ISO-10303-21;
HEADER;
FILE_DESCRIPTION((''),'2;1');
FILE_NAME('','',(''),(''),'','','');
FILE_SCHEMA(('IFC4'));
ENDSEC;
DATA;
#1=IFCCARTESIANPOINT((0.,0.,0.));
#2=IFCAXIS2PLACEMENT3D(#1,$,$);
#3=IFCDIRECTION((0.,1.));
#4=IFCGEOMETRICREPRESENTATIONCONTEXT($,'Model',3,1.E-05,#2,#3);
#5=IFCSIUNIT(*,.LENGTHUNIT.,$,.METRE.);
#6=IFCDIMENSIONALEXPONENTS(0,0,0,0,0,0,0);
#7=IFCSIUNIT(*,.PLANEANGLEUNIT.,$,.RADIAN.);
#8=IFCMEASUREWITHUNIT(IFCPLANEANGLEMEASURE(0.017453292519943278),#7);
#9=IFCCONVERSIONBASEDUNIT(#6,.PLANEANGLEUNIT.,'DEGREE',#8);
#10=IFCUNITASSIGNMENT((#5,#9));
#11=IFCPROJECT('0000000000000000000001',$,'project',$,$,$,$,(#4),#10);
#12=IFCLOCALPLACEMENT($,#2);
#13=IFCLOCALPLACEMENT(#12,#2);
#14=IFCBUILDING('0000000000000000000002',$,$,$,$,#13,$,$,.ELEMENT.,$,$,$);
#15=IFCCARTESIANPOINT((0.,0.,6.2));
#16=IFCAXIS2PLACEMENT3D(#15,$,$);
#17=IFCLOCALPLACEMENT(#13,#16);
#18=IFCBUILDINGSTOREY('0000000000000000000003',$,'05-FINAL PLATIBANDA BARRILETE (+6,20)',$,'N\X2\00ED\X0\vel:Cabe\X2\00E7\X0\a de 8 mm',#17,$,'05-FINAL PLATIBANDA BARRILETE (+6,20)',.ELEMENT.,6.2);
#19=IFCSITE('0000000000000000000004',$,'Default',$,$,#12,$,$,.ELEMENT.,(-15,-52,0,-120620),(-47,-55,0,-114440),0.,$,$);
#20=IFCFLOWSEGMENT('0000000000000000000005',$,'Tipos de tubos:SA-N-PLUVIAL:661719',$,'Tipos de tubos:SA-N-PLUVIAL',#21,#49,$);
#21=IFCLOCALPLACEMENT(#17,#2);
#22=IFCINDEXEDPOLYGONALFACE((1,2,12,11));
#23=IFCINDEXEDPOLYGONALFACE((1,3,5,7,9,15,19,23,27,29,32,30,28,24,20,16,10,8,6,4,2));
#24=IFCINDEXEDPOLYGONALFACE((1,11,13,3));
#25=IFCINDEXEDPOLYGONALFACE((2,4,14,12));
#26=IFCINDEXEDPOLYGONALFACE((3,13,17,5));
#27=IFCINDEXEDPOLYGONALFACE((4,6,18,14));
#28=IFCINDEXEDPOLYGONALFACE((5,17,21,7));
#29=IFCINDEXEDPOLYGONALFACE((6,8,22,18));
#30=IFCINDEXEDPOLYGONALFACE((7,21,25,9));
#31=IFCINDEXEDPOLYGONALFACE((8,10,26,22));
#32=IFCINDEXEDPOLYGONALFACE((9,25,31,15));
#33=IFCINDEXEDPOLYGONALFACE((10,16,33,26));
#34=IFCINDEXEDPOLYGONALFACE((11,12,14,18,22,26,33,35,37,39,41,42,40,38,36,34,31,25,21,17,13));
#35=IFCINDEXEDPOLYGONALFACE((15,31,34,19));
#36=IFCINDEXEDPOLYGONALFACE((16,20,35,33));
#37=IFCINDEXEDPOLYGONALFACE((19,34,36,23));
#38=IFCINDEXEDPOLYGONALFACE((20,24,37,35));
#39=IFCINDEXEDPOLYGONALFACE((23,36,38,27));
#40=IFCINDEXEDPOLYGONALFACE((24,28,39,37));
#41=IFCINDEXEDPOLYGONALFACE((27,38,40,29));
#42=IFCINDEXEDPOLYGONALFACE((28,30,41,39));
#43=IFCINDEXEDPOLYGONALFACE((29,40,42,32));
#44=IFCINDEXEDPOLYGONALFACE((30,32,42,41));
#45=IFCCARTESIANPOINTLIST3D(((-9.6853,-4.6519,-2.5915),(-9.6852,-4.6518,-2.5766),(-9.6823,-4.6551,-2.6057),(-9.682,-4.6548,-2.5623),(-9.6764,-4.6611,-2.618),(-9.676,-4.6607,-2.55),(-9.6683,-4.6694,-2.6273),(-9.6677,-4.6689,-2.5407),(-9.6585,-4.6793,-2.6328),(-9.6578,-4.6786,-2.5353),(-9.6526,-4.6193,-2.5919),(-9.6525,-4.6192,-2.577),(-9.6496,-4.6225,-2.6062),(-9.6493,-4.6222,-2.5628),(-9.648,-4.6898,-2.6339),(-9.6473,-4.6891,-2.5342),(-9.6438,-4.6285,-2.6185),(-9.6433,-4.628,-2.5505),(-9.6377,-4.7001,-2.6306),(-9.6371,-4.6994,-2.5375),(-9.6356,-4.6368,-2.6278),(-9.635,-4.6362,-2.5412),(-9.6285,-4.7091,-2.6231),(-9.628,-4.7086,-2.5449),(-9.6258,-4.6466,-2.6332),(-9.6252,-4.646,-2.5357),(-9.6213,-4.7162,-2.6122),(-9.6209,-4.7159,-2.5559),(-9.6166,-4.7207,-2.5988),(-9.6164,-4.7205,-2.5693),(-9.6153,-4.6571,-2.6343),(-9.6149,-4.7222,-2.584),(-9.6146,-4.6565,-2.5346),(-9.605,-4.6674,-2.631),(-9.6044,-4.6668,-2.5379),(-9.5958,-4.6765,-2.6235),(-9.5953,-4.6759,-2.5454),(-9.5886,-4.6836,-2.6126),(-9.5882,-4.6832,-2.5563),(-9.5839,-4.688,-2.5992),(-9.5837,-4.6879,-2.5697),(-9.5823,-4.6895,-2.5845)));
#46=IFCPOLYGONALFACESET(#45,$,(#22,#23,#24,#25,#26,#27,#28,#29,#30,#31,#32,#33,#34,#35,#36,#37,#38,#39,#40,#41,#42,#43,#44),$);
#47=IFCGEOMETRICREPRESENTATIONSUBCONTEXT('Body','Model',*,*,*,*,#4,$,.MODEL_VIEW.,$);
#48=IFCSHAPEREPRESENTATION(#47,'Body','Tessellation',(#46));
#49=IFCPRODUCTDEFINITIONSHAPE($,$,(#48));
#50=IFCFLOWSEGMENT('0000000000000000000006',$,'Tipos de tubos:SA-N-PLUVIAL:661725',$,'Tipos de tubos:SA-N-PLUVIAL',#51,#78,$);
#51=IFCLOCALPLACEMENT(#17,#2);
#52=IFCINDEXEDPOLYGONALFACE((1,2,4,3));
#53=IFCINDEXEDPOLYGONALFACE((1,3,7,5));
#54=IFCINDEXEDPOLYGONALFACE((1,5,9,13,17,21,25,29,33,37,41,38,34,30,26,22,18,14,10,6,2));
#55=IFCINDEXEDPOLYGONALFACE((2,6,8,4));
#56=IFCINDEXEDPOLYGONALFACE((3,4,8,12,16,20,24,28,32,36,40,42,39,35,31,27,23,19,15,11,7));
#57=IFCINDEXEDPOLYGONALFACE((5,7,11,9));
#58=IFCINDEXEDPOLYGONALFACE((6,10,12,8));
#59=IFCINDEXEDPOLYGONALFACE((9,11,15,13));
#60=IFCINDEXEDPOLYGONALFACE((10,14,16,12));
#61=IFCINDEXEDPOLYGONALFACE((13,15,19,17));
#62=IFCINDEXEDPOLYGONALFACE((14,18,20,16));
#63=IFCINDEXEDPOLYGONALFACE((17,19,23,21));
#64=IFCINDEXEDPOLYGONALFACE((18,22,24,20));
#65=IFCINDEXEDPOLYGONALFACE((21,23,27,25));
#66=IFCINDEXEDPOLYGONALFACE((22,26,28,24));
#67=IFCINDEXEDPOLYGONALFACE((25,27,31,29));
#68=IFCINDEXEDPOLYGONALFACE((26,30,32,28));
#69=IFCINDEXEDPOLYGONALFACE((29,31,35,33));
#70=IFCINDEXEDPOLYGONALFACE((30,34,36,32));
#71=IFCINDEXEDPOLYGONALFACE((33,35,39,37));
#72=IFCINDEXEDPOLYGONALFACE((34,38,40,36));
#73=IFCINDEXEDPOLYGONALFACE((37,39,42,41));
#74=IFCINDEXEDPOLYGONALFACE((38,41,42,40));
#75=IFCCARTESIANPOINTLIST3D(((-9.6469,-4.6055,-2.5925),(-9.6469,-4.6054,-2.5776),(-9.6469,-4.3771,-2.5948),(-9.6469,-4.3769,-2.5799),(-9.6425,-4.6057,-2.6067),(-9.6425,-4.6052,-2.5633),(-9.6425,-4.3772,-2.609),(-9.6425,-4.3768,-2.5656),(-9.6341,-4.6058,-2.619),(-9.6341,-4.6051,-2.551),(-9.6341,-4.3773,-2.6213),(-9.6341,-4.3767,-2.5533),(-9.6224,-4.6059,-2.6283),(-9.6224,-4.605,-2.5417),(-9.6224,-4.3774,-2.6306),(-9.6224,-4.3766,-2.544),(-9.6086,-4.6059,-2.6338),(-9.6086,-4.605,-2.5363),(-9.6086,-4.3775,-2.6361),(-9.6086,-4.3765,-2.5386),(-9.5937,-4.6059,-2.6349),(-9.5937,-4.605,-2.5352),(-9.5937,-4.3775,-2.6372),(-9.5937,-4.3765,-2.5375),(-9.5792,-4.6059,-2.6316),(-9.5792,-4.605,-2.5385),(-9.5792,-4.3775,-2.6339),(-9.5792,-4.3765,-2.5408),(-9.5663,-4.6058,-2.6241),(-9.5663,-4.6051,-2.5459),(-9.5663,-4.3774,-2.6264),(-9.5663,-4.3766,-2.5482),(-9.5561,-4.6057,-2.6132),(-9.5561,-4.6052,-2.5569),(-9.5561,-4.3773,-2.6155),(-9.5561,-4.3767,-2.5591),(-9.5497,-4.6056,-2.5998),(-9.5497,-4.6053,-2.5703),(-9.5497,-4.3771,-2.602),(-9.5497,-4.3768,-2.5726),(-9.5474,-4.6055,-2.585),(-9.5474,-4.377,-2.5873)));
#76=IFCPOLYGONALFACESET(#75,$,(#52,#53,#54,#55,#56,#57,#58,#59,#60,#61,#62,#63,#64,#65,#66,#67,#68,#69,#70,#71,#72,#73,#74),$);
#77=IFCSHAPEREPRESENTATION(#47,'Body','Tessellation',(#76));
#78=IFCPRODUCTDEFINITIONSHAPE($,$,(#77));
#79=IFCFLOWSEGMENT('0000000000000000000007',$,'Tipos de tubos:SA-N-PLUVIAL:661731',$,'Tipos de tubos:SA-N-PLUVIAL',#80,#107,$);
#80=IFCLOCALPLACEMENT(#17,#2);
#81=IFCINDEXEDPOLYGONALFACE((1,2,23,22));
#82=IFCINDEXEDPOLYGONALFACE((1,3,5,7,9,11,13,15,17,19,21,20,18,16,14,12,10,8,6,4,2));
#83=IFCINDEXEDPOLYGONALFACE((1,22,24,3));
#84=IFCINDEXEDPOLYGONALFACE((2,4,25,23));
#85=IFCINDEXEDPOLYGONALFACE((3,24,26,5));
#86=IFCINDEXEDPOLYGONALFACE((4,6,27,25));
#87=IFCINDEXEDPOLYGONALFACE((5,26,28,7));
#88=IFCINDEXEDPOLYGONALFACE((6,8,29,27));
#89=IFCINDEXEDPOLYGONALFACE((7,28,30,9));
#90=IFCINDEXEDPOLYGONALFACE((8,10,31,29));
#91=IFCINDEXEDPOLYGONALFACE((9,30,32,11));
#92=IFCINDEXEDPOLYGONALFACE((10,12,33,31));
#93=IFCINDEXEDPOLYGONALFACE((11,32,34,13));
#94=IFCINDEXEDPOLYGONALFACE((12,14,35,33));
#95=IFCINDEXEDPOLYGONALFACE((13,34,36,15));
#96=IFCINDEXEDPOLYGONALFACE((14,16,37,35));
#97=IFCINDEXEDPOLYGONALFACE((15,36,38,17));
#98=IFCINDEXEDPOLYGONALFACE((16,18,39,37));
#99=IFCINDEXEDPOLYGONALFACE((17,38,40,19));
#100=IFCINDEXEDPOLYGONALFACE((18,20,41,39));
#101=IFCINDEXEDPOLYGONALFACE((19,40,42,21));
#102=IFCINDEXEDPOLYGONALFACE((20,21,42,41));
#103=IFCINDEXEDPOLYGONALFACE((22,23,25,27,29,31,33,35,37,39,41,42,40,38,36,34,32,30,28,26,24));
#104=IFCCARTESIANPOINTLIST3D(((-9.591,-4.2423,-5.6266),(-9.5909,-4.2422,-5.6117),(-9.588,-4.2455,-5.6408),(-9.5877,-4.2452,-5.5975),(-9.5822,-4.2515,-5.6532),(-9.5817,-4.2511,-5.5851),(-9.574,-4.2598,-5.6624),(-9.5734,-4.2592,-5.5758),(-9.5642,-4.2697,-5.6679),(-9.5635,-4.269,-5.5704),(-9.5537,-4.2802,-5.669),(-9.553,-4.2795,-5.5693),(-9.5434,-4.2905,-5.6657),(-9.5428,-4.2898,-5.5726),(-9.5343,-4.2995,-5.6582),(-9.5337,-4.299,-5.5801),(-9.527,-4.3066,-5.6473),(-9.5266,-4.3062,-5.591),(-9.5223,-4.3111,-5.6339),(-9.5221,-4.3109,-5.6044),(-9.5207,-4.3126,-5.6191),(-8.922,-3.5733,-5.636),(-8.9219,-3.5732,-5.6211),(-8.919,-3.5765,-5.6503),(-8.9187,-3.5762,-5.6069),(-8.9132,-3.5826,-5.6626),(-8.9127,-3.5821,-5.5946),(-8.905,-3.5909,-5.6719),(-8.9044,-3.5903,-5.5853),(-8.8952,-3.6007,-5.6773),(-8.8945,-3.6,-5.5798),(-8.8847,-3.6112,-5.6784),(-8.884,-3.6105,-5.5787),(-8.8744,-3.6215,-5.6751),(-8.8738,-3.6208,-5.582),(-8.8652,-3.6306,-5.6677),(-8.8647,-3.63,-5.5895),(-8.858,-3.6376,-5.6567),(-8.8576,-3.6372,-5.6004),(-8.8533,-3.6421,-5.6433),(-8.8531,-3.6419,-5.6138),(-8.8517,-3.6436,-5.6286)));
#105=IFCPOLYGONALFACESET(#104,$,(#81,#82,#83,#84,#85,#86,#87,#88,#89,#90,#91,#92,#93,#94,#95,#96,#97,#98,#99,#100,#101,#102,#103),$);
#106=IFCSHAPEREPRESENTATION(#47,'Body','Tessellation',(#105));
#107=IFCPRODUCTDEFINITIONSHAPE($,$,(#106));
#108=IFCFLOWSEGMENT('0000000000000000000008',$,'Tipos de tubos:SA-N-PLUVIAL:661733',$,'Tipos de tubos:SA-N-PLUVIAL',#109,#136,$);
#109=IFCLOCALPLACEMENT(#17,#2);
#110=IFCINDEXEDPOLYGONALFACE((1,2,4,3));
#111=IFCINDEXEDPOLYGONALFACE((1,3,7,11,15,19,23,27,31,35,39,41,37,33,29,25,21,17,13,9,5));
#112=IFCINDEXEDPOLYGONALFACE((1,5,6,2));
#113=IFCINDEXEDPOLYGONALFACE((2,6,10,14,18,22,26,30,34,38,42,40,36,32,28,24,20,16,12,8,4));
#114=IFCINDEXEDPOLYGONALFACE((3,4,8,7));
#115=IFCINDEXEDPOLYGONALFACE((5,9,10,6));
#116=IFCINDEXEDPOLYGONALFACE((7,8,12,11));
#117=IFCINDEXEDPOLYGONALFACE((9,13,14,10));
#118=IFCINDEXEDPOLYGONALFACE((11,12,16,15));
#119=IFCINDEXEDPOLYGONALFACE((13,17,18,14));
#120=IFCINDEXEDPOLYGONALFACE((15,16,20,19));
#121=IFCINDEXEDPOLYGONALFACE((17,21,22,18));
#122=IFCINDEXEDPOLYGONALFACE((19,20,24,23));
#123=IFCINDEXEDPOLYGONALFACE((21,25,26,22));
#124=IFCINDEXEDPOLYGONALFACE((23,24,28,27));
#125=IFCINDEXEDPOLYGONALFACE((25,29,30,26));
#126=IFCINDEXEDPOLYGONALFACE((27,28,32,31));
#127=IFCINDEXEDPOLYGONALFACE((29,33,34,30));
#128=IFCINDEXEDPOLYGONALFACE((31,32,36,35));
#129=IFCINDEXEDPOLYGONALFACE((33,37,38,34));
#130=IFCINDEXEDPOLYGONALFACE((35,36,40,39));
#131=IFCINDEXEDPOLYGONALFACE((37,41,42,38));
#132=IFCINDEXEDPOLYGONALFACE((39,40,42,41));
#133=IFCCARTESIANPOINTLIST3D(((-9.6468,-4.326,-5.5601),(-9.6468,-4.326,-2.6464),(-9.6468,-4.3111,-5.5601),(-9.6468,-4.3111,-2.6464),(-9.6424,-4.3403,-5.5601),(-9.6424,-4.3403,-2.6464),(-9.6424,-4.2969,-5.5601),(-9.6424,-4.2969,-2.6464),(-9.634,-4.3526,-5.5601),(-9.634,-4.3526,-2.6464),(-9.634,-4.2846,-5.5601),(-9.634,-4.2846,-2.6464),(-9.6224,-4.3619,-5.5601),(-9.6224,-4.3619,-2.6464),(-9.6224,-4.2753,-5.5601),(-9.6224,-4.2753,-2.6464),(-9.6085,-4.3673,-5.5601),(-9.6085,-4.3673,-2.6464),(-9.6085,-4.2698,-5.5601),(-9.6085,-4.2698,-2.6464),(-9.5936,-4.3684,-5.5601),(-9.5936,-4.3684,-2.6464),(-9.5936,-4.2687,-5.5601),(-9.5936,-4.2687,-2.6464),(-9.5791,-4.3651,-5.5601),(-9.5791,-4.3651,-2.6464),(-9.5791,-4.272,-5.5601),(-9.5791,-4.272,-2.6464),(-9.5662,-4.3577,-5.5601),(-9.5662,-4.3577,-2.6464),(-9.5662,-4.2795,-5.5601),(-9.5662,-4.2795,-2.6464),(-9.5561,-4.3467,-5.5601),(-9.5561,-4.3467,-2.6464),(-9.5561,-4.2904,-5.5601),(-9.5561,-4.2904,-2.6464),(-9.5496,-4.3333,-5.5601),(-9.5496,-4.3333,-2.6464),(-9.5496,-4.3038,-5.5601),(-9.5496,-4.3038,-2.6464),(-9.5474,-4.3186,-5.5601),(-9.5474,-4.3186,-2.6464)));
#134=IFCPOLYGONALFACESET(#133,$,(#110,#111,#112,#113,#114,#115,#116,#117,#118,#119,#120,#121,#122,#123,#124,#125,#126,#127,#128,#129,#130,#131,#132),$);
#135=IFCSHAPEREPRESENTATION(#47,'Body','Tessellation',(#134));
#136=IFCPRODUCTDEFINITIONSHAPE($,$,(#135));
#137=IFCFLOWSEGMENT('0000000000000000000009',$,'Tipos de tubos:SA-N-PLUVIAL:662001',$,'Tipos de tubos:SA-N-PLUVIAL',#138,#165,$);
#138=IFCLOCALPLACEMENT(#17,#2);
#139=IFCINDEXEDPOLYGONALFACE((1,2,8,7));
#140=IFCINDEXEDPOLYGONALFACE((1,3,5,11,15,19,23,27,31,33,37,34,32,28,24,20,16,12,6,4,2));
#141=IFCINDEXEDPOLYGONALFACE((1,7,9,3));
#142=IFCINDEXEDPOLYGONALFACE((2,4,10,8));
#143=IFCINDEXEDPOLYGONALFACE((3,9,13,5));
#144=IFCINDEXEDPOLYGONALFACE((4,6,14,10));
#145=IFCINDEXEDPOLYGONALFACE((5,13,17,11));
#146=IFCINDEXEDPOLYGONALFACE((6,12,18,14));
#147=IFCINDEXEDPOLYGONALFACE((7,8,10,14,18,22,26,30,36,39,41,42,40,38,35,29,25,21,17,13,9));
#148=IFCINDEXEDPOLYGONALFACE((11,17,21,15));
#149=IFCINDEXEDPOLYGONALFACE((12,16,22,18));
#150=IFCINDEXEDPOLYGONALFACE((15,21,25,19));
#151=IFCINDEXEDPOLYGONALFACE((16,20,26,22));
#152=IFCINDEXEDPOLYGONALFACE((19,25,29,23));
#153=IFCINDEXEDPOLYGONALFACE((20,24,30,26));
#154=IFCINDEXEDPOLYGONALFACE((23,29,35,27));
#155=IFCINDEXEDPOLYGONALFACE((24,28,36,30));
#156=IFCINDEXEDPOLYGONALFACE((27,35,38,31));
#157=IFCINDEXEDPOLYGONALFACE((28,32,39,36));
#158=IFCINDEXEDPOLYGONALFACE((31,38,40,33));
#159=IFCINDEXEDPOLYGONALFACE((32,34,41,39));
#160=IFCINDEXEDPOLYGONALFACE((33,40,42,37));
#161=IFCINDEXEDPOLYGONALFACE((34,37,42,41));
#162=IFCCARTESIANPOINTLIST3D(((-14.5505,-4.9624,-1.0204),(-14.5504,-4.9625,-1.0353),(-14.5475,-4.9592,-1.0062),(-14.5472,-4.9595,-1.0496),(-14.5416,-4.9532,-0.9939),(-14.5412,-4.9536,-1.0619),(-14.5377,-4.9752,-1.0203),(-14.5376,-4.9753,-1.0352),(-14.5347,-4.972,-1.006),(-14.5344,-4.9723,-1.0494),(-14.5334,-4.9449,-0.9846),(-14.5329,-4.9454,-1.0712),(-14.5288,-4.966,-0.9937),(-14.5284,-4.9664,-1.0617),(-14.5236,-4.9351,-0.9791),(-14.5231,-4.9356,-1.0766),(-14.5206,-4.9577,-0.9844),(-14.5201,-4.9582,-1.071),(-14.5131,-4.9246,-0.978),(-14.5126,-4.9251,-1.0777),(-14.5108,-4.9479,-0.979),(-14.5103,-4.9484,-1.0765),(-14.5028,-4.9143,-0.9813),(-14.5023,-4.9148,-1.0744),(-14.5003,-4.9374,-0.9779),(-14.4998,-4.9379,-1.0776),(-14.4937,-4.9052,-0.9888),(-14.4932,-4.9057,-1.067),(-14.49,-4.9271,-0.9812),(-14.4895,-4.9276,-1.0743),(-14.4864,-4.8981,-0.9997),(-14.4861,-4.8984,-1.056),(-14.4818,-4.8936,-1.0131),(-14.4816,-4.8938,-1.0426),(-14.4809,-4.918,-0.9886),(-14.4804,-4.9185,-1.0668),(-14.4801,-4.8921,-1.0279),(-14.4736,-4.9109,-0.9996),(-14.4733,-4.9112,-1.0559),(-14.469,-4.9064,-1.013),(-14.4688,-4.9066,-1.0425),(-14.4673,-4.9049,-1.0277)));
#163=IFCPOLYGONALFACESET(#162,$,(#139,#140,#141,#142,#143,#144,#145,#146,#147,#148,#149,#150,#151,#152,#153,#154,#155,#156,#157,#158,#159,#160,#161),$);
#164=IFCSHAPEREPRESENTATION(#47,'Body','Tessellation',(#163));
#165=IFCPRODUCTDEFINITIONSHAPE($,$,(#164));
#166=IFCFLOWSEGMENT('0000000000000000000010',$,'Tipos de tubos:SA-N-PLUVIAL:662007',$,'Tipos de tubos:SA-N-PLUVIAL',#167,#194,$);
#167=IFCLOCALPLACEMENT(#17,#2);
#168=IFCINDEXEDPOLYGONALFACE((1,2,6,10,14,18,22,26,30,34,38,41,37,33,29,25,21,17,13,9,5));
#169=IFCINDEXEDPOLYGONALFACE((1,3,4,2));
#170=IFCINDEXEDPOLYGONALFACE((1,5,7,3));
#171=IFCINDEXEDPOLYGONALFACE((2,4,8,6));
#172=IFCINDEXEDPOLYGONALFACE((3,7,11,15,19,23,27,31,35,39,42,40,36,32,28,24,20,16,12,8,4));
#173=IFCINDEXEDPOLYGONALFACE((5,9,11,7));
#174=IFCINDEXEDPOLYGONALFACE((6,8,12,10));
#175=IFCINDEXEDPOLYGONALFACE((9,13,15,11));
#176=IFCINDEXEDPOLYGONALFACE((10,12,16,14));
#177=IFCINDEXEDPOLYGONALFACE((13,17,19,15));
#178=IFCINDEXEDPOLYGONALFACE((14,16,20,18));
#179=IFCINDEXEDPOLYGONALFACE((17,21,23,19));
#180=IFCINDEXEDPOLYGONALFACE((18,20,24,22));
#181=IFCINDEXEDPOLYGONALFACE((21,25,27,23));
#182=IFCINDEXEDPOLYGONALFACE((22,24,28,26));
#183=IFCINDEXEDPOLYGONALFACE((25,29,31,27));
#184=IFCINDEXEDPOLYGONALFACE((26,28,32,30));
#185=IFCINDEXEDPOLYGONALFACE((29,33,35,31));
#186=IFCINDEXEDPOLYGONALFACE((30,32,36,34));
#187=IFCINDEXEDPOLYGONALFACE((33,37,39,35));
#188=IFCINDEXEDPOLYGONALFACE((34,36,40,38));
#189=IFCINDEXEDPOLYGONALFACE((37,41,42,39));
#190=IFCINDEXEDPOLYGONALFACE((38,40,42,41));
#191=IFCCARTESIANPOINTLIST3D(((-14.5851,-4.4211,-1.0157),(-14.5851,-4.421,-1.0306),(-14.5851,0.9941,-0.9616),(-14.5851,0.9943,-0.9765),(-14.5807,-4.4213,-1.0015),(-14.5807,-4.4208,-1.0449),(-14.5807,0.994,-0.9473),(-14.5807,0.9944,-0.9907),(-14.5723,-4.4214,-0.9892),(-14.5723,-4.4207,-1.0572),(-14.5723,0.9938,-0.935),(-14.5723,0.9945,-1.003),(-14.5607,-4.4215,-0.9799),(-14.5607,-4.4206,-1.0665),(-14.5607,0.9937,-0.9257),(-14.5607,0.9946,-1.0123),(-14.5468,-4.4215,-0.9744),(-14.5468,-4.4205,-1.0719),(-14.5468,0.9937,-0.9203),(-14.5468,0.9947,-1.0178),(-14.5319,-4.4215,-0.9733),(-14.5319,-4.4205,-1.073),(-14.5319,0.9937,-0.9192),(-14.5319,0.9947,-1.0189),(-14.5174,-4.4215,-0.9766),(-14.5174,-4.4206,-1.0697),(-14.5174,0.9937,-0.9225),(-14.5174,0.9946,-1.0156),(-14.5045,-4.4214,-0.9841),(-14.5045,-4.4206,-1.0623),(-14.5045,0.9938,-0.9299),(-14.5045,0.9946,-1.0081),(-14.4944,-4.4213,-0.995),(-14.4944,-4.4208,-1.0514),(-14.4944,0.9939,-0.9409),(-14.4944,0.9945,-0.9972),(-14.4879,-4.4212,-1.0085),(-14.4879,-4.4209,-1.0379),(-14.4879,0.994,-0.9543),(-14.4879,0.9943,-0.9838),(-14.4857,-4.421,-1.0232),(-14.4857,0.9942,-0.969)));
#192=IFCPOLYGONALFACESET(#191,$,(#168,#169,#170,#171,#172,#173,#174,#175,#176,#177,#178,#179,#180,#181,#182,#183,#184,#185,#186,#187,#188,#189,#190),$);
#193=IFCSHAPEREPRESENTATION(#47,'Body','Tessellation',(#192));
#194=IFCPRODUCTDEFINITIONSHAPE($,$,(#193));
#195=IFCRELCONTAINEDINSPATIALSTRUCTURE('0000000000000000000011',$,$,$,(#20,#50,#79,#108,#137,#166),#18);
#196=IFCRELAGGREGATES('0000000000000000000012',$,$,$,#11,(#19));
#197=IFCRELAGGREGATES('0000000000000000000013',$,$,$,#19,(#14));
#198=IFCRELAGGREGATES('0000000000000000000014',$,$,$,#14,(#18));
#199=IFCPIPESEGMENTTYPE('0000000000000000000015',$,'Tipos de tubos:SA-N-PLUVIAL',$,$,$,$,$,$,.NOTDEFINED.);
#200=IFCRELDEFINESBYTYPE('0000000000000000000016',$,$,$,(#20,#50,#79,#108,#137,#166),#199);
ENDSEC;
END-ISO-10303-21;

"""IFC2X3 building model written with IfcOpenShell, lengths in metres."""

from ifc_helpers import new_model, entity, si_unit, converted_unit, direction, frame, frame_2d, origin, origin_2d_with_axis, place, context, subcontext, project, spatial, circle, extrude, type_object, element, save


model = new_model("IFC2X3")

# Units and contexts
model_context = context("Model", 3, precision=1e-05, world=origin(), true_north=direction((0.0, 1.0)))
body_context = subcontext(model_context, "Body", "Model", "MODEL_VIEW")
ifc_project = project(units=[si_unit("LENGTHUNIT", "METRE"), converted_unit("PLANEANGLEUNIT", "DEGREE", entity("IfcPlaneAngleMeasure", 0.017453292519943278), si_unit("PLANEANGLEUNIT", "RADIAN"), dimensions=[0, 0, 0, 0, 0, 0, 0])], contexts=[model_context])

# Site, building, storey
site_placement = place(None, origin())
site = spatial("IfcSite", under=ifc_project, at=site_placement, Name="Default", CompositionType="ELEMENT", RefLatitude=(-15, -52, 0, -120620), RefLongitude=(-47, -55, 0, -114440), RefElevation=0.0)
building_placement = place(site_placement, origin())
building = spatial("IfcBuilding", under=site, at=building_placement, CompositionType="ELEMENT")
storey_placement = place(building_placement, frame((0.0, 0.0, 6.2)))
storey = spatial("IfcBuildingStorey", under=building, at=storey_placement, Name="05-FINAL PLATIBANDA BARRILETE (+6,20)", ObjectType="Nível:Cabeça de 8 mm", LongName="05-FINAL PLATIBANDA BARRILETE (+6,20)", CompositionType="ELEMENT", Elevation=6.2)

# Flow segments
pipe_segment_type_1 = type_object("IfcPipeSegmentType", Name="Tipos de tubos:SA-N-PLUVIAL", PredefinedType="NOTDEFINED")
flow_segment_1_placement = place(storey_placement, origin())
element("IfcFlowSegment", 1, at=flow_segment_1_placement, inside=storey, type_object=pipe_segment_type_1, Name="Tipos de tubos:SA-N-PLUVIAL:661719", ObjectType="Tipos de tubos:SA-N-PLUVIAL", context=body_context, shape_type="SweptSolid", body=[
    extrude(circle(Radius=0.05, at=origin_2d_with_axis()), frame((-9.6503, -4.6868, -2.584), z_axis=(0.707073, 0.707076, -0.009551), x_axis=(0.707109, -0.707105, 0.0)), (0.0, 0.0, 1.0), 0.0462),
])
flow_segment_2_placement = place(storey_placement, origin())
element("IfcFlowSegment", 2, at=flow_segment_2_placement, inside=storey, type_object=pipe_segment_type_1, Name="Tipos de tubos:SA-N-PLUVIAL:661725", ObjectType="Tipos de tubos:SA-N-PLUVIAL", context=body_context, shape_type="SweptSolid", body=[
    extrude(circle(Radius=0.05, at=frame_2d((0.0, 0.0), x_axis=(1.0, 0.0))), frame((-9.5974, -4.377, -2.5873), z_axis=(0.000001, -0.99995, 0.01), x_axis=(1.0, 0.000001, 0.0)), (0.0, 0.0, 1.0), 0.2285),
])
flow_segment_3_placement = place(storey_placement, origin())
element("IfcFlowSegment", 3, at=flow_segment_3_placement, inside=storey, type_object=pipe_segment_type_1, Name="Tipos de tubos:SA-N-PLUVIAL:661731", ObjectType="Tipos de tubos:SA-N-PLUVIAL", context=body_context, shape_type="SweptSolid", body=[
    extrude(circle(Radius=0.05, at=frame_2d((0.0, 0.0), x_axis=(1.0, 0.0))), frame((-8.887, -3.6082, -5.6286), z_axis=(-0.707088, -0.707056, 0.009973), x_axis=(0.707091, -0.707123, 0.0)), (0.0, 0.0, 1.0), 0.9462),
])
flow_segment_4_placement = place(storey_placement, origin())
element("IfcFlowSegment", 4, at=flow_segment_4_placement, inside=storey, type_object=pipe_segment_type_1, Name="Tipos de tubos:SA-N-PLUVIAL:661733", ObjectType="Tipos de tubos:SA-N-PLUVIAL", context=body_context, shape_type="SweptSolid", body=[
    extrude(circle(Radius=0.05, at=frame_2d((0.0, 0.0), x_axis=(1.0, 0.0))), frame((-9.5974, -4.3186, -5.5601)), (0.0, 0.0, 1.0), 2.9137),
])
flow_segment_5_placement = place(storey_placement, origin())
element("IfcFlowSegment", 5, at=flow_segment_5_placement, inside=storey, type_object=pipe_segment_type_1, Name="Tipos de tubos:SA-N-PLUVIAL:662001", ObjectType="Tipos de tubos:SA-N-PLUVIAL", context=body_context, shape_type="SweptSolid", body=[
    extrude(circle(Radius=0.05, at=frame_2d((0.0, 0.0), x_axis=(1.0, 0.0))), frame((-14.5155, -4.9275, -1.0279), z_axis=(0.707086, -0.707085, 0.007693), x_axis=(0.707106, 0.707107, 0.0)), (0.0, 0.0, 1.0), 0.0181),
])
flow_segment_6_placement = place(storey_placement, origin())
element("IfcFlowSegment", 6, at=flow_segment_6_placement, inside=storey, type_object=pipe_segment_type_1, Name="Tipos de tubos:SA-N-PLUVIAL:662007", ObjectType="Tipos de tubos:SA-N-PLUVIAL", context=body_context, shape_type="SweptSolid", body=[
    extrude(circle(Radius=0.05, at=frame_2d((0.0, 0.0), x_axis=(1.0, 0.0))), frame((-14.5357, -4.421, -1.0232), z_axis=(-0.000001, 0.99995, 0.01), x_axis=(1.0, 0.000001, 0.0)), (0.0, 0.0, 1.0), 5.4155),
])

save(model, "model.ifc")
